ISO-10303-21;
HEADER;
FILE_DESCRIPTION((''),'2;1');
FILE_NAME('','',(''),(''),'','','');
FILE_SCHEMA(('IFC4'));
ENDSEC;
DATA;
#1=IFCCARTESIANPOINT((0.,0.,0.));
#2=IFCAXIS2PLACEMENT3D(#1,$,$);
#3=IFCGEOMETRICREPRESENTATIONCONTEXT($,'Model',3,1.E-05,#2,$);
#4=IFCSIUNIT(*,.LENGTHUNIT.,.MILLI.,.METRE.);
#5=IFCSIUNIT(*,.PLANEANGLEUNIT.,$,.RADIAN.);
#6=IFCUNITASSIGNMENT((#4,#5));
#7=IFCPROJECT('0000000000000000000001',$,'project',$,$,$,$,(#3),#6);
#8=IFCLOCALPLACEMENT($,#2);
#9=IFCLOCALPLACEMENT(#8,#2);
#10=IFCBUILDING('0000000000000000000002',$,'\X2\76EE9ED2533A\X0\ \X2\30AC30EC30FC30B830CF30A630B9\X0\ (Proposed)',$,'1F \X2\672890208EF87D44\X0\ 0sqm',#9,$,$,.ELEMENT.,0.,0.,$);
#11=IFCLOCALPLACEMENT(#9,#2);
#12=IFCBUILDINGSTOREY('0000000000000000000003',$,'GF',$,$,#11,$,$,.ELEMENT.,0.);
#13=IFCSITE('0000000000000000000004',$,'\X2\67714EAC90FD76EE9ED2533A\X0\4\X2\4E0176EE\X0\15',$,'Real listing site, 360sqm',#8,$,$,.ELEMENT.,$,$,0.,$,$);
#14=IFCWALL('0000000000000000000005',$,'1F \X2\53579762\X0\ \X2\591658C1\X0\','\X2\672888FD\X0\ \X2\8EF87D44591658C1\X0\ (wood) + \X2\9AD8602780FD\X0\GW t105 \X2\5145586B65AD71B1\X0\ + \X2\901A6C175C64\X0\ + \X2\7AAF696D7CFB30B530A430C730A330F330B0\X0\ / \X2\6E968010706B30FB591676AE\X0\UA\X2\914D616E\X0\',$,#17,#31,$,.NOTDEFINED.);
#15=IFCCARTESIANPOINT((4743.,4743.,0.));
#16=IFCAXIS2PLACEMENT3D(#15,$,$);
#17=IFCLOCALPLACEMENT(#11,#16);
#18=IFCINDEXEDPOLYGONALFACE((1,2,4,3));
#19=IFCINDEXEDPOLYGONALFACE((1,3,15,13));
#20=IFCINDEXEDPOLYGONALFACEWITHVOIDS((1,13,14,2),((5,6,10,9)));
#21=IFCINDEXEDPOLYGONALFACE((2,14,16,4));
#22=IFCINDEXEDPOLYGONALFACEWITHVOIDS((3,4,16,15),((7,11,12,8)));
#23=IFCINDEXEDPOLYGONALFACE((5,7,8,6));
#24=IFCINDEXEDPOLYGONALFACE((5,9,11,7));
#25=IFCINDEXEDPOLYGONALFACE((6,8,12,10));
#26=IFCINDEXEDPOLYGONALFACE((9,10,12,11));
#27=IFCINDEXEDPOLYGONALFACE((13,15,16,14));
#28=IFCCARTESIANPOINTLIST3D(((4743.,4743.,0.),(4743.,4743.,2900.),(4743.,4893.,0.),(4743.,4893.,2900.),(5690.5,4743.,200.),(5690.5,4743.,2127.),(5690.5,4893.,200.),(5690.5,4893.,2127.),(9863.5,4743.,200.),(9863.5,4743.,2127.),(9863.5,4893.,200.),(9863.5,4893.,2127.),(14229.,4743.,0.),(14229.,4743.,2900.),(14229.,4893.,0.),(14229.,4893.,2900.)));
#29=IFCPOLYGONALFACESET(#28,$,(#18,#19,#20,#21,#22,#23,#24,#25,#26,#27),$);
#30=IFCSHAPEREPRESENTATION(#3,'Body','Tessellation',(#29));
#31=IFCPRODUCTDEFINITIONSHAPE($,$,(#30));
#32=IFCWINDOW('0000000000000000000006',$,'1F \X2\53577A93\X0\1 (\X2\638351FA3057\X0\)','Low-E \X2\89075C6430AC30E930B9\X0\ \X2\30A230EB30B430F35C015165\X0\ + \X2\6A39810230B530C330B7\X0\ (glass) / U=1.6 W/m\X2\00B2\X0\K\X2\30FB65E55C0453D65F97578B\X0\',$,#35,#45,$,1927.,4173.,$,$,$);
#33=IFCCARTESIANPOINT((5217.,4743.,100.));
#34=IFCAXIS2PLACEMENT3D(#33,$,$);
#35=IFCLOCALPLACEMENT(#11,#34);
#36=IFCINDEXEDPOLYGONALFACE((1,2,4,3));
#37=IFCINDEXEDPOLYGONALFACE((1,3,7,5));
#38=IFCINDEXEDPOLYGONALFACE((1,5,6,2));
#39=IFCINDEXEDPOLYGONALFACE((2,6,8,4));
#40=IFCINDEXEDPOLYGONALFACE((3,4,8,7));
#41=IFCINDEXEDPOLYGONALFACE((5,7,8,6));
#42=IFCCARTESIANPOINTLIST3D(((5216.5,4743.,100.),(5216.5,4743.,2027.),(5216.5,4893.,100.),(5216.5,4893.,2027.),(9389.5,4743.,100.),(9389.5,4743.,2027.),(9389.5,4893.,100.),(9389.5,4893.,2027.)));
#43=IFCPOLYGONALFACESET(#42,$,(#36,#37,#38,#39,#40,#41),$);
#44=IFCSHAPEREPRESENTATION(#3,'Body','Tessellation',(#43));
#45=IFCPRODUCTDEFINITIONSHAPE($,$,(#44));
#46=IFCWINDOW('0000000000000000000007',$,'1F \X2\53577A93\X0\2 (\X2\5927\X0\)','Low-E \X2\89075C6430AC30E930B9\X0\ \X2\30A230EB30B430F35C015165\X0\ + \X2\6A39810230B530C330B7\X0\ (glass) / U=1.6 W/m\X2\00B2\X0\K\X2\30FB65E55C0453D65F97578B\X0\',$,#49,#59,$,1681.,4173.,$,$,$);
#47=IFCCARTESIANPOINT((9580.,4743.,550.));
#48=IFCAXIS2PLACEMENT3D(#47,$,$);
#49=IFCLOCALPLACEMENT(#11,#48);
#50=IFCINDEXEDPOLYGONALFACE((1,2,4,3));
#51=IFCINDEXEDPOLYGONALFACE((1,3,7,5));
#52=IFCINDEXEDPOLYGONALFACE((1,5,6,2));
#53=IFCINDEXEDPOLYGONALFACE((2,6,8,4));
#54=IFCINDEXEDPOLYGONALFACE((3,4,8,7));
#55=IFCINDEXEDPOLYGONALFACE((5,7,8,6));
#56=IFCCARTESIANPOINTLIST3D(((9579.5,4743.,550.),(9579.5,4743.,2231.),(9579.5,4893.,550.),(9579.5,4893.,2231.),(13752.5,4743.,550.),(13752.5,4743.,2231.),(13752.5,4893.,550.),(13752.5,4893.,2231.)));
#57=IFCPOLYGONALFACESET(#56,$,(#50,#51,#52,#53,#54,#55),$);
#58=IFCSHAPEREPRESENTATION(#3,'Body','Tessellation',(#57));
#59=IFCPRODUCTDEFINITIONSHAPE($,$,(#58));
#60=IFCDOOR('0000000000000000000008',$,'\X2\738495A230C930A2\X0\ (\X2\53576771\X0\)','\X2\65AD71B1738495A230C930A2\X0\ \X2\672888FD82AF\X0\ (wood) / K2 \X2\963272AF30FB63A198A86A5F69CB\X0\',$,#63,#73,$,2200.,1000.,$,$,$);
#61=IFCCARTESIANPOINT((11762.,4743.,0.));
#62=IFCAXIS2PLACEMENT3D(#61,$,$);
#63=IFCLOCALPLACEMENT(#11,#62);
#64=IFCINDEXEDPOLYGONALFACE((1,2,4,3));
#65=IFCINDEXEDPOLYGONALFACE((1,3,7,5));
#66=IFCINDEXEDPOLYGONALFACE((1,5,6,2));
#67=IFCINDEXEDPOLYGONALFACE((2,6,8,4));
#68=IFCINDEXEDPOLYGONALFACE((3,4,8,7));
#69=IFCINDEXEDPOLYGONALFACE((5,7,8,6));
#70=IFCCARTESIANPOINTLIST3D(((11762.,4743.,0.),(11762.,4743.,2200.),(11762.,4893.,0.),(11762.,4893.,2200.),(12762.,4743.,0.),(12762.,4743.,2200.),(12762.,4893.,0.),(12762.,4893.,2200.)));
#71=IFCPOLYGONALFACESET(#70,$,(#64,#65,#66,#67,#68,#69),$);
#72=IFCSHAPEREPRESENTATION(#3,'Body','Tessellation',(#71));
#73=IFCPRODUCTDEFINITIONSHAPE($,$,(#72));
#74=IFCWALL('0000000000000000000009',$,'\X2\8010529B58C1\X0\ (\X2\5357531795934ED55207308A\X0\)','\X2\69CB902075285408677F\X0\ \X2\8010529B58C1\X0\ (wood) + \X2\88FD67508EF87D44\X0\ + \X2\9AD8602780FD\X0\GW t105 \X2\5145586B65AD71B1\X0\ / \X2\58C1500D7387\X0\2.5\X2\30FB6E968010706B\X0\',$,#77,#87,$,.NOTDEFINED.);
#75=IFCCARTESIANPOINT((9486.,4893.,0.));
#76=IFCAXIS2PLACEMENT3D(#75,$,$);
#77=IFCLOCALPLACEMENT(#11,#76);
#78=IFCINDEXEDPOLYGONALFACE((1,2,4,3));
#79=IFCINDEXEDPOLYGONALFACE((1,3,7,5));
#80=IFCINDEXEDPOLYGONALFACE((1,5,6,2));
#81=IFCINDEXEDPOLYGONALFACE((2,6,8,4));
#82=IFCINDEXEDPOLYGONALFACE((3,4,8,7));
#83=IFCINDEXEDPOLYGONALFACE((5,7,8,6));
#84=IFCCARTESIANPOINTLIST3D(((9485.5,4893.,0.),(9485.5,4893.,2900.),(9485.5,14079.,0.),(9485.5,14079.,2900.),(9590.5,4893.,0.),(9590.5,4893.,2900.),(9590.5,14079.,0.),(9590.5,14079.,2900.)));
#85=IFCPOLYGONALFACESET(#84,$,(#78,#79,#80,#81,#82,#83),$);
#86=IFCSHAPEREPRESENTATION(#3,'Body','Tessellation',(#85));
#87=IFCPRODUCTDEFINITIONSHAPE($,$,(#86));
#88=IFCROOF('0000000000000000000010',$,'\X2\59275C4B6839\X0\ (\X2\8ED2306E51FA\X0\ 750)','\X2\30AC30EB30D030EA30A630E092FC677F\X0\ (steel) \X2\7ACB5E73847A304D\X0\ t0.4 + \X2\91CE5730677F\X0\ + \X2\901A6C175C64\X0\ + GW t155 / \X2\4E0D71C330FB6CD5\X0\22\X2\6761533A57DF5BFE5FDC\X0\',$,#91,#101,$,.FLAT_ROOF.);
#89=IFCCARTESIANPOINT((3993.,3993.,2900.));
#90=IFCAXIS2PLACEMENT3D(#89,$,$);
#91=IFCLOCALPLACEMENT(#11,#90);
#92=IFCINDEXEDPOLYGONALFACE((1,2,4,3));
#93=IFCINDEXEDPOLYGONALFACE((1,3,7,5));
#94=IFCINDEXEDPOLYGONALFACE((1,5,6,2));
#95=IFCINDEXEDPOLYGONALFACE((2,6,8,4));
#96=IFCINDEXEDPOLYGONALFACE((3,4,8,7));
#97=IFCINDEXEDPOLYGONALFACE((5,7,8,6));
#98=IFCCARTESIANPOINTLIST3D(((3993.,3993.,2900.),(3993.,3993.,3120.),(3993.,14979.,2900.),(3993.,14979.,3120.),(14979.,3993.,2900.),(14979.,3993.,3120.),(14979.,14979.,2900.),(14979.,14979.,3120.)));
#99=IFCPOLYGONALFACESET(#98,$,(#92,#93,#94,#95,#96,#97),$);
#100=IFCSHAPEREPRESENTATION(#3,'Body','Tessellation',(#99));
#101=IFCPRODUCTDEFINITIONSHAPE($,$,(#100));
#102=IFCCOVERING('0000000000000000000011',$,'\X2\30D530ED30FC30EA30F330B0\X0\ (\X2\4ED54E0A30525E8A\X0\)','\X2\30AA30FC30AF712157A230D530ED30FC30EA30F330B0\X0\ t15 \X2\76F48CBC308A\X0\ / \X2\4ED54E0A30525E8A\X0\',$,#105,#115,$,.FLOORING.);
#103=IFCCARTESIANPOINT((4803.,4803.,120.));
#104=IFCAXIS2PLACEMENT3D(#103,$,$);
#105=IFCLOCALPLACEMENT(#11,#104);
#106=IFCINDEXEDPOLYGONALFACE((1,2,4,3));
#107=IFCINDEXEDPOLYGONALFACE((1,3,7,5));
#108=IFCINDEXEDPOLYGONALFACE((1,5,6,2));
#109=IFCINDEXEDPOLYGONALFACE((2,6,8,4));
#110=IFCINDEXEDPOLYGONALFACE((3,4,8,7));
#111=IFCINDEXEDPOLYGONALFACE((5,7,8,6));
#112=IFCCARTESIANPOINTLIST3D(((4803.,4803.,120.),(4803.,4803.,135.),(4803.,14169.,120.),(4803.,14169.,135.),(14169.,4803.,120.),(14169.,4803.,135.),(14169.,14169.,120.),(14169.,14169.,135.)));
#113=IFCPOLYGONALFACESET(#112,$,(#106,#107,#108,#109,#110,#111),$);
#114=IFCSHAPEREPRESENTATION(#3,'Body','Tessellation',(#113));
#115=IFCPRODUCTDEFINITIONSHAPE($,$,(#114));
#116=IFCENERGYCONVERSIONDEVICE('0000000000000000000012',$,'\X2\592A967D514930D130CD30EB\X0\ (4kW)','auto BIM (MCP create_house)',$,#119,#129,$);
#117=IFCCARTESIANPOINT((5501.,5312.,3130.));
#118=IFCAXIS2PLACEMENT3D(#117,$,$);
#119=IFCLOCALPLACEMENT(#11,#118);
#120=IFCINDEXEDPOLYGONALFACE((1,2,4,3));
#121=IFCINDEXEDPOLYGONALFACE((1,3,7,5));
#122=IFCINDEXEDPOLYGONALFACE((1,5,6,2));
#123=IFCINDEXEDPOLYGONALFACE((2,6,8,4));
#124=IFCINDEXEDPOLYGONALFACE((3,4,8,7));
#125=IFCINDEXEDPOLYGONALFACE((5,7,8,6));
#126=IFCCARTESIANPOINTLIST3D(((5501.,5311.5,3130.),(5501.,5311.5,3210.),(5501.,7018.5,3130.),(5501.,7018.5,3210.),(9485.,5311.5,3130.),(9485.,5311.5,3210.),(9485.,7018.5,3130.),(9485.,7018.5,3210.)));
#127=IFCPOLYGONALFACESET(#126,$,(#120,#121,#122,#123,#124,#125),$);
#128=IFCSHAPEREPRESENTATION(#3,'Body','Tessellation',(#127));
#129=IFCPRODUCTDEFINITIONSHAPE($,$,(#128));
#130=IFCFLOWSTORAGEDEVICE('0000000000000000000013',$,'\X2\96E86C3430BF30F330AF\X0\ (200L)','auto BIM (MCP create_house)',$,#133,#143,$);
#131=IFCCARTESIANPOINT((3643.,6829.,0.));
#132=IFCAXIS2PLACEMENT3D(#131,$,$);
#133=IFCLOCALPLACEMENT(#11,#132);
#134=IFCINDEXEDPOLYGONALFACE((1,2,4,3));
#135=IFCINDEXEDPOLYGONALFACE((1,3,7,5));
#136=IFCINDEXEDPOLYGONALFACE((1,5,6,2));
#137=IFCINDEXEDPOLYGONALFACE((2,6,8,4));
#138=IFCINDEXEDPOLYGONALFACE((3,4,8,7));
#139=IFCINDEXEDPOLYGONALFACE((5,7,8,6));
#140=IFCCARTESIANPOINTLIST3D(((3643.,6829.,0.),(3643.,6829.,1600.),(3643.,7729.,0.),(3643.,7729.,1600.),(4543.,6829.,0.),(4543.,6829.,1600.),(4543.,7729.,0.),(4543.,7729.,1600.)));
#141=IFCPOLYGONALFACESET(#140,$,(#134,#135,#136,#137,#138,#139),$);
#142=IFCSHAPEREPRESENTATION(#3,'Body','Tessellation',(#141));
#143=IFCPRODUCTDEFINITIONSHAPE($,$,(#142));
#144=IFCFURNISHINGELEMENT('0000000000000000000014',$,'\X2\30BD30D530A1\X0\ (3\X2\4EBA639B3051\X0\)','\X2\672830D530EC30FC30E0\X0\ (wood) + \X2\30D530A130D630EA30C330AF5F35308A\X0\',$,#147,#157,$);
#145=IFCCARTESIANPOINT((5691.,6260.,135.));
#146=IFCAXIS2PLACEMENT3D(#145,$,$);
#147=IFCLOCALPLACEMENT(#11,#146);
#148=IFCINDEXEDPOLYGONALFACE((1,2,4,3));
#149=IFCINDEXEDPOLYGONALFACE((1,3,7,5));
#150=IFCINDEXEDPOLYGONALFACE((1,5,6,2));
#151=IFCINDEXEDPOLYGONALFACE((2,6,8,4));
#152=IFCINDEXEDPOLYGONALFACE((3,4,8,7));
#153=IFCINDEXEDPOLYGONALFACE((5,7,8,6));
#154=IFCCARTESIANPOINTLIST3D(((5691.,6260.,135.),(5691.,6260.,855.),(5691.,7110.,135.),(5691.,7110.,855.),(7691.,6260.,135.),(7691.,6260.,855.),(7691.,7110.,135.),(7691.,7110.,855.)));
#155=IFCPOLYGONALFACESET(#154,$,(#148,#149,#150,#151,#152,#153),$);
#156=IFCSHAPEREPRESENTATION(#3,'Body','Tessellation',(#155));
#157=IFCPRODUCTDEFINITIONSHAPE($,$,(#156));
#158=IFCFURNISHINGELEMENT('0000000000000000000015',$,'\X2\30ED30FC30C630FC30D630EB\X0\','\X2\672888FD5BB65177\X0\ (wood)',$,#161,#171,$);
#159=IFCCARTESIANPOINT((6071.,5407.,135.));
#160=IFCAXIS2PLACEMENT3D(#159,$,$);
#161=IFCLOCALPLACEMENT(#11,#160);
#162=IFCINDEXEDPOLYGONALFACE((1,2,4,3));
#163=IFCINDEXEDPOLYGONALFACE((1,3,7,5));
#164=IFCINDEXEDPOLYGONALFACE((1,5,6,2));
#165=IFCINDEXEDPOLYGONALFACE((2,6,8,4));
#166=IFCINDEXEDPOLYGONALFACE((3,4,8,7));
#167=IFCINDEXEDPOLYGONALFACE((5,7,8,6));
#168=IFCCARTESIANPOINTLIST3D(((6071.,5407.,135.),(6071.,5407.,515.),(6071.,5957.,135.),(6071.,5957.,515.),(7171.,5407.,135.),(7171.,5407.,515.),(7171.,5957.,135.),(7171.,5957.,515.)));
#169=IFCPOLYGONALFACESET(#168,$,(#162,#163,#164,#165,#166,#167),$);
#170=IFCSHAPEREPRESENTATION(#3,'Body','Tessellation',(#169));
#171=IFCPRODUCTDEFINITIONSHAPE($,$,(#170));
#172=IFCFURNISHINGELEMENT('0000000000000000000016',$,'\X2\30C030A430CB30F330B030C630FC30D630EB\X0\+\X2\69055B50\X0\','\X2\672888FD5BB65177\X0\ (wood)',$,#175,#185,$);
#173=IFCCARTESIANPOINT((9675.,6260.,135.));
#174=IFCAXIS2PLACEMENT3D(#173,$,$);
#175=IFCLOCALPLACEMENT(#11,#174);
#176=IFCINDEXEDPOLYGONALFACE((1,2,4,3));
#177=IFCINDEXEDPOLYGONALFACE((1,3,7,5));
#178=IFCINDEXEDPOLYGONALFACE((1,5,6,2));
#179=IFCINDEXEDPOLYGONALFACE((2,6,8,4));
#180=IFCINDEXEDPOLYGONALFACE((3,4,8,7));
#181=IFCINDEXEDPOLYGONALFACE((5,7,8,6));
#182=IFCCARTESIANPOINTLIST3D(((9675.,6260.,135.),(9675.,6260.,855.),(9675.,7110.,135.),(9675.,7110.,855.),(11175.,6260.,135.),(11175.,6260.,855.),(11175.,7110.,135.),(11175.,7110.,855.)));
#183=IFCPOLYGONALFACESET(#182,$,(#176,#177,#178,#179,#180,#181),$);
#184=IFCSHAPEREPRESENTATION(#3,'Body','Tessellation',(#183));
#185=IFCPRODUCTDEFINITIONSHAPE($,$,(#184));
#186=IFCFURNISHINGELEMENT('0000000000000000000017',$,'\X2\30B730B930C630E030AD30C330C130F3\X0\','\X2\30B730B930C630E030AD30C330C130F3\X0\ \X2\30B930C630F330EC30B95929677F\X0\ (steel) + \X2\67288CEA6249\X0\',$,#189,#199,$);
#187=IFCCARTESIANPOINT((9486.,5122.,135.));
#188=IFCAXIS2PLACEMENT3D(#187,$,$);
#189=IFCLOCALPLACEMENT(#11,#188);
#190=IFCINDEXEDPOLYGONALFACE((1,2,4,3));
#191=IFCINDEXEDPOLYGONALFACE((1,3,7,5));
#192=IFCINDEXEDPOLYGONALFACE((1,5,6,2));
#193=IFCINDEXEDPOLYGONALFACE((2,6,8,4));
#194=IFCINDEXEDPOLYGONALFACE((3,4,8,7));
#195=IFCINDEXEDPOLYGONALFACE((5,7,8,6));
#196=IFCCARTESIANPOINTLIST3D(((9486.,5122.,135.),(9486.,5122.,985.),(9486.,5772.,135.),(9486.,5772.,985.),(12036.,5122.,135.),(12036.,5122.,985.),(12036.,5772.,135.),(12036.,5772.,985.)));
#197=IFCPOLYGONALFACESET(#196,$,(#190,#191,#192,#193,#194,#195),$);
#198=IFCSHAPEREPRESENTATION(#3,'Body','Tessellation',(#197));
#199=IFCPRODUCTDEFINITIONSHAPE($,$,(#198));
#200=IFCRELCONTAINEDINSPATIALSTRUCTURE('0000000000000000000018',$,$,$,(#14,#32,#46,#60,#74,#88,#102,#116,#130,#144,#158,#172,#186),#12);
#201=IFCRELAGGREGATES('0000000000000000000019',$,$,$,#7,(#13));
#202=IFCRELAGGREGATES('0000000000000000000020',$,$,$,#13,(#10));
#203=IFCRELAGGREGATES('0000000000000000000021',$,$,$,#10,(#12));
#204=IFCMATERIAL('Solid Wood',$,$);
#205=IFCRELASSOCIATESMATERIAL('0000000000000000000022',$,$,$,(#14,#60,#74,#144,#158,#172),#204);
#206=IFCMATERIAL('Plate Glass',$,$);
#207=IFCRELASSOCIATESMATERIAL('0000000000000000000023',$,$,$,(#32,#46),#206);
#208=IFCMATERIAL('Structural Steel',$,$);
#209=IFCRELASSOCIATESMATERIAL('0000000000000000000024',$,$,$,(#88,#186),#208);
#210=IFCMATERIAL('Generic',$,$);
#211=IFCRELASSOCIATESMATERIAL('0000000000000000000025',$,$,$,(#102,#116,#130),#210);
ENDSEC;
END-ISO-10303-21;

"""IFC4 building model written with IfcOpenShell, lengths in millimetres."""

from ifc_helpers import new_model, si_unit, frame, frame_2d, origin, place, context, project, spatial, rectangle, extrude, material, element, fill, save


model = new_model("IFC4")

# Units and contexts
model_context = context("Model", 3, precision=1e-05, world=origin())
ifc_project = project(units=[si_unit("LENGTHUNIT", "METRE", prefix="MILLI"), si_unit("PLANEANGLEUNIT", "RADIAN")], contexts=[model_context])

# Site, building, storey
site_placement = place(None, origin())
site = spatial("IfcSite", under=ifc_project, at=site_placement, Name="東京都目黒区4丁目15", ObjectType="Real listing site, 360sqm", CompositionType="ELEMENT", RefElevation=0.0)
building_placement = place(site_placement, origin())
building = spatial("IfcBuilding", under=site, at=building_placement, Name="目黒区 ガレージハウス (Proposed)", ObjectType="1F 木造軸組 0sqm", CompositionType="ELEMENT", ElevationOfRefHeight=0.0, ElevationOfTerrain=0.0)
storey_placement = place(building_placement, origin())
storey = spatial("IfcBuildingStorey", under=building, at=storey_placement, Name="GF", CompositionType="ELEMENT", Elevation=0.0)

# Shared definitions
ifc_material_1 = material(Name="Solid Wood")

# Wall, openings, windows, door
wall_1_placement = place(storey_placement, frame((4743.0, 4743.0, 0.0)))
wall_1 = element("IfcWall", 1, at=wall_1_placement, inside=storey, material=ifc_material_1, Name="1F 南面 外壁", Description="木製 軸組外壁 (wood) + 高性能GW t105 充填断熱 + 通気層 + 窯業系サイディング / 準耐火・外皮UA配慮", PredefinedType="NOTDEFINED", context=model_context, shape_type="SweptSolid", body=[
    extrude(rectangle(XDim=9486.0, YDim=150.0, at=frame_2d((4743.0, 75.0))), frame((4743.0, 4743.0, 0.0)), (0.0, 0.0, 1.0), 2900.0),
])
opening_1_placement = place(storey_placement, frame((5217.0, 4743.0, 100.0)))
opening_1 = element("IfcOpeningElement", 2, at=opening_1_placement, cuts=wall_1, PredefinedType="NOTDEFINED", context=model_context, shape_type="SweptSolid", body=[
    extrude(rectangle(XDim=4173.0, YDim=150.0, at=frame_2d((2086.0, 75.0))), frame((5217.0, 4743.0, 100.0)), (0.0, 0.0, 1.0), 1927.0),
])
opening_2_placement = place(storey_placement, frame((9580.0, 4743.0, 550.0)))
opening_2 = element("IfcOpeningElement", 3, at=opening_2_placement, cuts=wall_1, PredefinedType="NOTDEFINED", context=model_context, shape_type="SweptSolid", body=[
    extrude(rectangle(XDim=4173.0, YDim=150.0, at=frame_2d((2086.0, 75.0))), frame((9580.0, 4743.0, 550.0)), (0.0, 0.0, 1.0), 1681.0),
])
opening_3_placement = place(storey_placement, frame((11762.0, 4743.0, 0.0)))
opening_3 = element("IfcOpeningElement", 4, at=opening_3_placement, cuts=wall_1, PredefinedType="NOTDEFINED", context=model_context, shape_type="SweptSolid", body=[
    extrude(rectangle(XDim=1000.0, YDim=150.0, at=frame_2d((500.0, 75.0))), frame((11762.0, 4743.0, 0.0)), (0.0, 0.0, 1.0), 2200.0),
])
ifc_material_2 = material(Name="Plate Glass")
window_1_placement = place(storey_placement, frame((5217.0, 4743.0, 100.0)))
window_1 = element("IfcWindow", 5, at=window_1_placement, inside=storey, material=ifc_material_2, Name="1F 南窓1 (掃出し)", Description="Low-E 複層ガラス アルゴン封入 + 樹脂サッシ (glass) / U=1.6 W/m²K・日射取得型", OverallHeight=1927.0, OverallWidth=4173.0, context=model_context, shape_type="SweptSolid", body=[
    extrude(rectangle(XDim=4173.0, YDim=150.0, at=frame_2d((2086.0, 75.0))), frame((5217.0, 4743.0, 100.0)), (0.0, 0.0, 1.0), 1927.0),
])
fill(opening_1, window_1)
window_2_placement = place(storey_placement, frame((9580.0, 4743.0, 550.0)))
window_2 = element("IfcWindow", 6, at=window_2_placement, inside=storey, material=ifc_material_2, Name="1F 南窓2 (大)", Description="Low-E 複層ガラス アルゴン封入 + 樹脂サッシ (glass) / U=1.6 W/m²K・日射取得型", OverallHeight=1681.0, OverallWidth=4173.0, context=model_context, shape_type="SweptSolid", body=[
    extrude(rectangle(XDim=4173.0, YDim=150.0, at=frame_2d((2086.0, 75.0))), frame((9580.0, 4743.0, 550.0)), (0.0, 0.0, 1.0), 1681.0),
])
fill(opening_2, window_2)
door_placement = place(storey_placement, frame((11762.0, 4743.0, 0.0)))
door = element("IfcDoor", 7, at=door_placement, inside=storey, material=ifc_material_1, Name="玄関ドア (南東)", Description="断熱玄関ドア 木製芯 (wood) / K2 防犯・採風機構", OverallHeight=2200.0, OverallWidth=1000.0, context=model_context, shape_type="SweptSolid", body=[
    extrude(rectangle(XDim=1000.0, YDim=150.0, at=frame_2d((500.0, 75.0))), frame((11762.0, 4743.0, 0.0)), (0.0, 0.0, 1.0), 2200.0),
])
fill(opening_3, door)

# Wall
wall_2_placement = place(storey_placement, frame((9486.0, 4893.0, 0.0)))
element("IfcWall", 8, at=wall_2_placement, inside=storey, material=ifc_material_1, Name="耐力壁 (南北間仕切り)", Description="構造用合板 耐力壁 (wood) + 製材軸組 + 高性能GW t105 充填断熱 / 壁倍率2.5・準耐火", PredefinedType="NOTDEFINED", context=model_context, shape_type="SweptSolid", body=[
    extrude(rectangle(XDim=105.0, YDim=9186.0, at=frame_2d((52.0, 4593.0))), frame((9486.0, 4893.0, 0.0)), (0.0, 0.0, 1.0), 2900.0),
])

# Roof
ifc_material_3 = material(Name="Structural Steel")
roof_placement = place(storey_placement, frame((3993.0, 3993.0, 2900.0)))
element("IfcRoof", 9, at=roof_placement, inside=storey, material=ifc_material_3, Name="大屋根 (軒の出 750)", Description="ガルバリウム鋼板 (steel) 立平葺き t0.4 + 野地板 + 通気層 + GW t155 / 不燃・法22条区域対応", PredefinedType="FLAT_ROOF", context=model_context, shape_type="SweptSolid", body=[
    extrude(rectangle(XDim=10986.0, YDim=10986.0, at=frame_2d((5493.0, 5493.0))), frame((3993.0, 3993.0, 2900.0)), (0.0, 0.0, 1.0), 220.0),
])

# Covering
ifc_material_4 = material(Name="Generic")
covering_placement = place(storey_placement, frame((4803.0, 4803.0, 120.0)))
element("IfcCovering", 10, at=covering_placement, inside=storey, material=ifc_material_4, Name="フローリング (仕上げ床)", Description="オーク無垢フローリング t15 直貼り / 仕上げ床", PredefinedType="FLOORING", context=model_context, shape_type="SweptSolid", body=[
    extrude(rectangle(XDim=9366.0, YDim=9366.0, at=frame_2d((4683.0, 4683.0))), frame((4803.0, 4803.0, 120.0)), (0.0, 0.0, 1.0), 15.0),
])

# Energy conversion device
energy_conversion_device_placement = place(storey_placement, frame((5501.0, 5312.0, 3130.0)))
element("IfcEnergyConversionDevice", 11, at=energy_conversion_device_placement, inside=storey, material=ifc_material_4, Name="太陽光パネル (4kW)", Description="auto BIM (MCP create_house)", context=model_context, shape_type="SweptSolid", body=[
    extrude(rectangle(XDim=3984.0, YDim=1707.0, at=frame_2d((1992.0, 853.0))), frame((5501.0, 5312.0, 3130.0)), (0.0, 0.0, 1.0), 80.0),
])

# Flow storage device
flow_storage_device_placement = place(storey_placement, frame((3643.0, 6829.0, 0.0)))
element("IfcFlowStorageDevice", 12, at=flow_storage_device_placement, inside=storey, material=ifc_material_4, Name="雨水タンク (200L)", Description="auto BIM (MCP create_house)", context=model_context, shape_type="SweptSolid", body=[
    extrude(rectangle(XDim=900.0, YDim=900.0, at=frame_2d((450.0, 450.0))), frame((3643.0, 6829.0, 0.0)), (0.0, 0.0, 1.0), 1600.0),
])

# Furnishing elements
furnishing_1_placement = place(storey_placement, frame((5691.0, 6260.0, 135.0)))
element("IfcFurnishingElement", 13, at=furnishing_1_placement, inside=storey, material=ifc_material_1, Name="ソファ (3人掛け)", Description="木フレーム (wood) + ファブリック張り", context=model_context, shape_type="SweptSolid", body=[
    extrude(rectangle(XDim=2000.0, YDim=850.0, at=frame_2d((1000.0, 425.0))), frame((5691.0, 6260.0, 135.0)), (0.0, 0.0, 1.0), 720.0),
])
furnishing_2_placement = place(storey_placement, frame((6071.0, 5407.0, 135.0)))
element("IfcFurnishingElement", 14, at=furnishing_2_placement, inside=storey, material=ifc_material_1, Name="ローテーブル", Description="木製家具 (wood)", context=model_context, shape_type="SweptSolid", body=[
    extrude(rectangle(XDim=1100.0, YDim=550.0, at=frame_2d((550.0, 275.0))), frame((6071.0, 5407.0, 135.0)), (0.0, 0.0, 1.0), 380.0),
])
furnishing_3_placement = place(storey_placement, frame((9675.0, 6260.0, 135.0)))
element("IfcFurnishingElement", 15, at=furnishing_3_placement, inside=storey, material=ifc_material_1, Name="ダイニングテーブル+椅子", Description="木製家具 (wood)", context=model_context, shape_type="SweptSolid", body=[
    extrude(rectangle(XDim=1500.0, YDim=850.0, at=frame_2d((750.0, 425.0))), frame((9675.0, 6260.0, 135.0)), (0.0, 0.0, 1.0), 720.0),
])
furnishing_4_placement = place(storey_placement, frame((9486.0, 5122.0, 135.0)))
element("IfcFurnishingElement", 16, at=furnishing_4_placement, inside=storey, material=ifc_material_3, Name="システムキッチン", Description="システムキッチン ステンレス天板 (steel) + 木質扉", context=model_context, shape_type="SweptSolid", body=[
    extrude(rectangle(XDim=2550.0, YDim=650.0, at=frame_2d((1275.0, 325.0))), frame((9486.0, 5122.0, 135.0)), (0.0, 0.0, 1.0), 850.0),
])

save(model, "model.ifc")
